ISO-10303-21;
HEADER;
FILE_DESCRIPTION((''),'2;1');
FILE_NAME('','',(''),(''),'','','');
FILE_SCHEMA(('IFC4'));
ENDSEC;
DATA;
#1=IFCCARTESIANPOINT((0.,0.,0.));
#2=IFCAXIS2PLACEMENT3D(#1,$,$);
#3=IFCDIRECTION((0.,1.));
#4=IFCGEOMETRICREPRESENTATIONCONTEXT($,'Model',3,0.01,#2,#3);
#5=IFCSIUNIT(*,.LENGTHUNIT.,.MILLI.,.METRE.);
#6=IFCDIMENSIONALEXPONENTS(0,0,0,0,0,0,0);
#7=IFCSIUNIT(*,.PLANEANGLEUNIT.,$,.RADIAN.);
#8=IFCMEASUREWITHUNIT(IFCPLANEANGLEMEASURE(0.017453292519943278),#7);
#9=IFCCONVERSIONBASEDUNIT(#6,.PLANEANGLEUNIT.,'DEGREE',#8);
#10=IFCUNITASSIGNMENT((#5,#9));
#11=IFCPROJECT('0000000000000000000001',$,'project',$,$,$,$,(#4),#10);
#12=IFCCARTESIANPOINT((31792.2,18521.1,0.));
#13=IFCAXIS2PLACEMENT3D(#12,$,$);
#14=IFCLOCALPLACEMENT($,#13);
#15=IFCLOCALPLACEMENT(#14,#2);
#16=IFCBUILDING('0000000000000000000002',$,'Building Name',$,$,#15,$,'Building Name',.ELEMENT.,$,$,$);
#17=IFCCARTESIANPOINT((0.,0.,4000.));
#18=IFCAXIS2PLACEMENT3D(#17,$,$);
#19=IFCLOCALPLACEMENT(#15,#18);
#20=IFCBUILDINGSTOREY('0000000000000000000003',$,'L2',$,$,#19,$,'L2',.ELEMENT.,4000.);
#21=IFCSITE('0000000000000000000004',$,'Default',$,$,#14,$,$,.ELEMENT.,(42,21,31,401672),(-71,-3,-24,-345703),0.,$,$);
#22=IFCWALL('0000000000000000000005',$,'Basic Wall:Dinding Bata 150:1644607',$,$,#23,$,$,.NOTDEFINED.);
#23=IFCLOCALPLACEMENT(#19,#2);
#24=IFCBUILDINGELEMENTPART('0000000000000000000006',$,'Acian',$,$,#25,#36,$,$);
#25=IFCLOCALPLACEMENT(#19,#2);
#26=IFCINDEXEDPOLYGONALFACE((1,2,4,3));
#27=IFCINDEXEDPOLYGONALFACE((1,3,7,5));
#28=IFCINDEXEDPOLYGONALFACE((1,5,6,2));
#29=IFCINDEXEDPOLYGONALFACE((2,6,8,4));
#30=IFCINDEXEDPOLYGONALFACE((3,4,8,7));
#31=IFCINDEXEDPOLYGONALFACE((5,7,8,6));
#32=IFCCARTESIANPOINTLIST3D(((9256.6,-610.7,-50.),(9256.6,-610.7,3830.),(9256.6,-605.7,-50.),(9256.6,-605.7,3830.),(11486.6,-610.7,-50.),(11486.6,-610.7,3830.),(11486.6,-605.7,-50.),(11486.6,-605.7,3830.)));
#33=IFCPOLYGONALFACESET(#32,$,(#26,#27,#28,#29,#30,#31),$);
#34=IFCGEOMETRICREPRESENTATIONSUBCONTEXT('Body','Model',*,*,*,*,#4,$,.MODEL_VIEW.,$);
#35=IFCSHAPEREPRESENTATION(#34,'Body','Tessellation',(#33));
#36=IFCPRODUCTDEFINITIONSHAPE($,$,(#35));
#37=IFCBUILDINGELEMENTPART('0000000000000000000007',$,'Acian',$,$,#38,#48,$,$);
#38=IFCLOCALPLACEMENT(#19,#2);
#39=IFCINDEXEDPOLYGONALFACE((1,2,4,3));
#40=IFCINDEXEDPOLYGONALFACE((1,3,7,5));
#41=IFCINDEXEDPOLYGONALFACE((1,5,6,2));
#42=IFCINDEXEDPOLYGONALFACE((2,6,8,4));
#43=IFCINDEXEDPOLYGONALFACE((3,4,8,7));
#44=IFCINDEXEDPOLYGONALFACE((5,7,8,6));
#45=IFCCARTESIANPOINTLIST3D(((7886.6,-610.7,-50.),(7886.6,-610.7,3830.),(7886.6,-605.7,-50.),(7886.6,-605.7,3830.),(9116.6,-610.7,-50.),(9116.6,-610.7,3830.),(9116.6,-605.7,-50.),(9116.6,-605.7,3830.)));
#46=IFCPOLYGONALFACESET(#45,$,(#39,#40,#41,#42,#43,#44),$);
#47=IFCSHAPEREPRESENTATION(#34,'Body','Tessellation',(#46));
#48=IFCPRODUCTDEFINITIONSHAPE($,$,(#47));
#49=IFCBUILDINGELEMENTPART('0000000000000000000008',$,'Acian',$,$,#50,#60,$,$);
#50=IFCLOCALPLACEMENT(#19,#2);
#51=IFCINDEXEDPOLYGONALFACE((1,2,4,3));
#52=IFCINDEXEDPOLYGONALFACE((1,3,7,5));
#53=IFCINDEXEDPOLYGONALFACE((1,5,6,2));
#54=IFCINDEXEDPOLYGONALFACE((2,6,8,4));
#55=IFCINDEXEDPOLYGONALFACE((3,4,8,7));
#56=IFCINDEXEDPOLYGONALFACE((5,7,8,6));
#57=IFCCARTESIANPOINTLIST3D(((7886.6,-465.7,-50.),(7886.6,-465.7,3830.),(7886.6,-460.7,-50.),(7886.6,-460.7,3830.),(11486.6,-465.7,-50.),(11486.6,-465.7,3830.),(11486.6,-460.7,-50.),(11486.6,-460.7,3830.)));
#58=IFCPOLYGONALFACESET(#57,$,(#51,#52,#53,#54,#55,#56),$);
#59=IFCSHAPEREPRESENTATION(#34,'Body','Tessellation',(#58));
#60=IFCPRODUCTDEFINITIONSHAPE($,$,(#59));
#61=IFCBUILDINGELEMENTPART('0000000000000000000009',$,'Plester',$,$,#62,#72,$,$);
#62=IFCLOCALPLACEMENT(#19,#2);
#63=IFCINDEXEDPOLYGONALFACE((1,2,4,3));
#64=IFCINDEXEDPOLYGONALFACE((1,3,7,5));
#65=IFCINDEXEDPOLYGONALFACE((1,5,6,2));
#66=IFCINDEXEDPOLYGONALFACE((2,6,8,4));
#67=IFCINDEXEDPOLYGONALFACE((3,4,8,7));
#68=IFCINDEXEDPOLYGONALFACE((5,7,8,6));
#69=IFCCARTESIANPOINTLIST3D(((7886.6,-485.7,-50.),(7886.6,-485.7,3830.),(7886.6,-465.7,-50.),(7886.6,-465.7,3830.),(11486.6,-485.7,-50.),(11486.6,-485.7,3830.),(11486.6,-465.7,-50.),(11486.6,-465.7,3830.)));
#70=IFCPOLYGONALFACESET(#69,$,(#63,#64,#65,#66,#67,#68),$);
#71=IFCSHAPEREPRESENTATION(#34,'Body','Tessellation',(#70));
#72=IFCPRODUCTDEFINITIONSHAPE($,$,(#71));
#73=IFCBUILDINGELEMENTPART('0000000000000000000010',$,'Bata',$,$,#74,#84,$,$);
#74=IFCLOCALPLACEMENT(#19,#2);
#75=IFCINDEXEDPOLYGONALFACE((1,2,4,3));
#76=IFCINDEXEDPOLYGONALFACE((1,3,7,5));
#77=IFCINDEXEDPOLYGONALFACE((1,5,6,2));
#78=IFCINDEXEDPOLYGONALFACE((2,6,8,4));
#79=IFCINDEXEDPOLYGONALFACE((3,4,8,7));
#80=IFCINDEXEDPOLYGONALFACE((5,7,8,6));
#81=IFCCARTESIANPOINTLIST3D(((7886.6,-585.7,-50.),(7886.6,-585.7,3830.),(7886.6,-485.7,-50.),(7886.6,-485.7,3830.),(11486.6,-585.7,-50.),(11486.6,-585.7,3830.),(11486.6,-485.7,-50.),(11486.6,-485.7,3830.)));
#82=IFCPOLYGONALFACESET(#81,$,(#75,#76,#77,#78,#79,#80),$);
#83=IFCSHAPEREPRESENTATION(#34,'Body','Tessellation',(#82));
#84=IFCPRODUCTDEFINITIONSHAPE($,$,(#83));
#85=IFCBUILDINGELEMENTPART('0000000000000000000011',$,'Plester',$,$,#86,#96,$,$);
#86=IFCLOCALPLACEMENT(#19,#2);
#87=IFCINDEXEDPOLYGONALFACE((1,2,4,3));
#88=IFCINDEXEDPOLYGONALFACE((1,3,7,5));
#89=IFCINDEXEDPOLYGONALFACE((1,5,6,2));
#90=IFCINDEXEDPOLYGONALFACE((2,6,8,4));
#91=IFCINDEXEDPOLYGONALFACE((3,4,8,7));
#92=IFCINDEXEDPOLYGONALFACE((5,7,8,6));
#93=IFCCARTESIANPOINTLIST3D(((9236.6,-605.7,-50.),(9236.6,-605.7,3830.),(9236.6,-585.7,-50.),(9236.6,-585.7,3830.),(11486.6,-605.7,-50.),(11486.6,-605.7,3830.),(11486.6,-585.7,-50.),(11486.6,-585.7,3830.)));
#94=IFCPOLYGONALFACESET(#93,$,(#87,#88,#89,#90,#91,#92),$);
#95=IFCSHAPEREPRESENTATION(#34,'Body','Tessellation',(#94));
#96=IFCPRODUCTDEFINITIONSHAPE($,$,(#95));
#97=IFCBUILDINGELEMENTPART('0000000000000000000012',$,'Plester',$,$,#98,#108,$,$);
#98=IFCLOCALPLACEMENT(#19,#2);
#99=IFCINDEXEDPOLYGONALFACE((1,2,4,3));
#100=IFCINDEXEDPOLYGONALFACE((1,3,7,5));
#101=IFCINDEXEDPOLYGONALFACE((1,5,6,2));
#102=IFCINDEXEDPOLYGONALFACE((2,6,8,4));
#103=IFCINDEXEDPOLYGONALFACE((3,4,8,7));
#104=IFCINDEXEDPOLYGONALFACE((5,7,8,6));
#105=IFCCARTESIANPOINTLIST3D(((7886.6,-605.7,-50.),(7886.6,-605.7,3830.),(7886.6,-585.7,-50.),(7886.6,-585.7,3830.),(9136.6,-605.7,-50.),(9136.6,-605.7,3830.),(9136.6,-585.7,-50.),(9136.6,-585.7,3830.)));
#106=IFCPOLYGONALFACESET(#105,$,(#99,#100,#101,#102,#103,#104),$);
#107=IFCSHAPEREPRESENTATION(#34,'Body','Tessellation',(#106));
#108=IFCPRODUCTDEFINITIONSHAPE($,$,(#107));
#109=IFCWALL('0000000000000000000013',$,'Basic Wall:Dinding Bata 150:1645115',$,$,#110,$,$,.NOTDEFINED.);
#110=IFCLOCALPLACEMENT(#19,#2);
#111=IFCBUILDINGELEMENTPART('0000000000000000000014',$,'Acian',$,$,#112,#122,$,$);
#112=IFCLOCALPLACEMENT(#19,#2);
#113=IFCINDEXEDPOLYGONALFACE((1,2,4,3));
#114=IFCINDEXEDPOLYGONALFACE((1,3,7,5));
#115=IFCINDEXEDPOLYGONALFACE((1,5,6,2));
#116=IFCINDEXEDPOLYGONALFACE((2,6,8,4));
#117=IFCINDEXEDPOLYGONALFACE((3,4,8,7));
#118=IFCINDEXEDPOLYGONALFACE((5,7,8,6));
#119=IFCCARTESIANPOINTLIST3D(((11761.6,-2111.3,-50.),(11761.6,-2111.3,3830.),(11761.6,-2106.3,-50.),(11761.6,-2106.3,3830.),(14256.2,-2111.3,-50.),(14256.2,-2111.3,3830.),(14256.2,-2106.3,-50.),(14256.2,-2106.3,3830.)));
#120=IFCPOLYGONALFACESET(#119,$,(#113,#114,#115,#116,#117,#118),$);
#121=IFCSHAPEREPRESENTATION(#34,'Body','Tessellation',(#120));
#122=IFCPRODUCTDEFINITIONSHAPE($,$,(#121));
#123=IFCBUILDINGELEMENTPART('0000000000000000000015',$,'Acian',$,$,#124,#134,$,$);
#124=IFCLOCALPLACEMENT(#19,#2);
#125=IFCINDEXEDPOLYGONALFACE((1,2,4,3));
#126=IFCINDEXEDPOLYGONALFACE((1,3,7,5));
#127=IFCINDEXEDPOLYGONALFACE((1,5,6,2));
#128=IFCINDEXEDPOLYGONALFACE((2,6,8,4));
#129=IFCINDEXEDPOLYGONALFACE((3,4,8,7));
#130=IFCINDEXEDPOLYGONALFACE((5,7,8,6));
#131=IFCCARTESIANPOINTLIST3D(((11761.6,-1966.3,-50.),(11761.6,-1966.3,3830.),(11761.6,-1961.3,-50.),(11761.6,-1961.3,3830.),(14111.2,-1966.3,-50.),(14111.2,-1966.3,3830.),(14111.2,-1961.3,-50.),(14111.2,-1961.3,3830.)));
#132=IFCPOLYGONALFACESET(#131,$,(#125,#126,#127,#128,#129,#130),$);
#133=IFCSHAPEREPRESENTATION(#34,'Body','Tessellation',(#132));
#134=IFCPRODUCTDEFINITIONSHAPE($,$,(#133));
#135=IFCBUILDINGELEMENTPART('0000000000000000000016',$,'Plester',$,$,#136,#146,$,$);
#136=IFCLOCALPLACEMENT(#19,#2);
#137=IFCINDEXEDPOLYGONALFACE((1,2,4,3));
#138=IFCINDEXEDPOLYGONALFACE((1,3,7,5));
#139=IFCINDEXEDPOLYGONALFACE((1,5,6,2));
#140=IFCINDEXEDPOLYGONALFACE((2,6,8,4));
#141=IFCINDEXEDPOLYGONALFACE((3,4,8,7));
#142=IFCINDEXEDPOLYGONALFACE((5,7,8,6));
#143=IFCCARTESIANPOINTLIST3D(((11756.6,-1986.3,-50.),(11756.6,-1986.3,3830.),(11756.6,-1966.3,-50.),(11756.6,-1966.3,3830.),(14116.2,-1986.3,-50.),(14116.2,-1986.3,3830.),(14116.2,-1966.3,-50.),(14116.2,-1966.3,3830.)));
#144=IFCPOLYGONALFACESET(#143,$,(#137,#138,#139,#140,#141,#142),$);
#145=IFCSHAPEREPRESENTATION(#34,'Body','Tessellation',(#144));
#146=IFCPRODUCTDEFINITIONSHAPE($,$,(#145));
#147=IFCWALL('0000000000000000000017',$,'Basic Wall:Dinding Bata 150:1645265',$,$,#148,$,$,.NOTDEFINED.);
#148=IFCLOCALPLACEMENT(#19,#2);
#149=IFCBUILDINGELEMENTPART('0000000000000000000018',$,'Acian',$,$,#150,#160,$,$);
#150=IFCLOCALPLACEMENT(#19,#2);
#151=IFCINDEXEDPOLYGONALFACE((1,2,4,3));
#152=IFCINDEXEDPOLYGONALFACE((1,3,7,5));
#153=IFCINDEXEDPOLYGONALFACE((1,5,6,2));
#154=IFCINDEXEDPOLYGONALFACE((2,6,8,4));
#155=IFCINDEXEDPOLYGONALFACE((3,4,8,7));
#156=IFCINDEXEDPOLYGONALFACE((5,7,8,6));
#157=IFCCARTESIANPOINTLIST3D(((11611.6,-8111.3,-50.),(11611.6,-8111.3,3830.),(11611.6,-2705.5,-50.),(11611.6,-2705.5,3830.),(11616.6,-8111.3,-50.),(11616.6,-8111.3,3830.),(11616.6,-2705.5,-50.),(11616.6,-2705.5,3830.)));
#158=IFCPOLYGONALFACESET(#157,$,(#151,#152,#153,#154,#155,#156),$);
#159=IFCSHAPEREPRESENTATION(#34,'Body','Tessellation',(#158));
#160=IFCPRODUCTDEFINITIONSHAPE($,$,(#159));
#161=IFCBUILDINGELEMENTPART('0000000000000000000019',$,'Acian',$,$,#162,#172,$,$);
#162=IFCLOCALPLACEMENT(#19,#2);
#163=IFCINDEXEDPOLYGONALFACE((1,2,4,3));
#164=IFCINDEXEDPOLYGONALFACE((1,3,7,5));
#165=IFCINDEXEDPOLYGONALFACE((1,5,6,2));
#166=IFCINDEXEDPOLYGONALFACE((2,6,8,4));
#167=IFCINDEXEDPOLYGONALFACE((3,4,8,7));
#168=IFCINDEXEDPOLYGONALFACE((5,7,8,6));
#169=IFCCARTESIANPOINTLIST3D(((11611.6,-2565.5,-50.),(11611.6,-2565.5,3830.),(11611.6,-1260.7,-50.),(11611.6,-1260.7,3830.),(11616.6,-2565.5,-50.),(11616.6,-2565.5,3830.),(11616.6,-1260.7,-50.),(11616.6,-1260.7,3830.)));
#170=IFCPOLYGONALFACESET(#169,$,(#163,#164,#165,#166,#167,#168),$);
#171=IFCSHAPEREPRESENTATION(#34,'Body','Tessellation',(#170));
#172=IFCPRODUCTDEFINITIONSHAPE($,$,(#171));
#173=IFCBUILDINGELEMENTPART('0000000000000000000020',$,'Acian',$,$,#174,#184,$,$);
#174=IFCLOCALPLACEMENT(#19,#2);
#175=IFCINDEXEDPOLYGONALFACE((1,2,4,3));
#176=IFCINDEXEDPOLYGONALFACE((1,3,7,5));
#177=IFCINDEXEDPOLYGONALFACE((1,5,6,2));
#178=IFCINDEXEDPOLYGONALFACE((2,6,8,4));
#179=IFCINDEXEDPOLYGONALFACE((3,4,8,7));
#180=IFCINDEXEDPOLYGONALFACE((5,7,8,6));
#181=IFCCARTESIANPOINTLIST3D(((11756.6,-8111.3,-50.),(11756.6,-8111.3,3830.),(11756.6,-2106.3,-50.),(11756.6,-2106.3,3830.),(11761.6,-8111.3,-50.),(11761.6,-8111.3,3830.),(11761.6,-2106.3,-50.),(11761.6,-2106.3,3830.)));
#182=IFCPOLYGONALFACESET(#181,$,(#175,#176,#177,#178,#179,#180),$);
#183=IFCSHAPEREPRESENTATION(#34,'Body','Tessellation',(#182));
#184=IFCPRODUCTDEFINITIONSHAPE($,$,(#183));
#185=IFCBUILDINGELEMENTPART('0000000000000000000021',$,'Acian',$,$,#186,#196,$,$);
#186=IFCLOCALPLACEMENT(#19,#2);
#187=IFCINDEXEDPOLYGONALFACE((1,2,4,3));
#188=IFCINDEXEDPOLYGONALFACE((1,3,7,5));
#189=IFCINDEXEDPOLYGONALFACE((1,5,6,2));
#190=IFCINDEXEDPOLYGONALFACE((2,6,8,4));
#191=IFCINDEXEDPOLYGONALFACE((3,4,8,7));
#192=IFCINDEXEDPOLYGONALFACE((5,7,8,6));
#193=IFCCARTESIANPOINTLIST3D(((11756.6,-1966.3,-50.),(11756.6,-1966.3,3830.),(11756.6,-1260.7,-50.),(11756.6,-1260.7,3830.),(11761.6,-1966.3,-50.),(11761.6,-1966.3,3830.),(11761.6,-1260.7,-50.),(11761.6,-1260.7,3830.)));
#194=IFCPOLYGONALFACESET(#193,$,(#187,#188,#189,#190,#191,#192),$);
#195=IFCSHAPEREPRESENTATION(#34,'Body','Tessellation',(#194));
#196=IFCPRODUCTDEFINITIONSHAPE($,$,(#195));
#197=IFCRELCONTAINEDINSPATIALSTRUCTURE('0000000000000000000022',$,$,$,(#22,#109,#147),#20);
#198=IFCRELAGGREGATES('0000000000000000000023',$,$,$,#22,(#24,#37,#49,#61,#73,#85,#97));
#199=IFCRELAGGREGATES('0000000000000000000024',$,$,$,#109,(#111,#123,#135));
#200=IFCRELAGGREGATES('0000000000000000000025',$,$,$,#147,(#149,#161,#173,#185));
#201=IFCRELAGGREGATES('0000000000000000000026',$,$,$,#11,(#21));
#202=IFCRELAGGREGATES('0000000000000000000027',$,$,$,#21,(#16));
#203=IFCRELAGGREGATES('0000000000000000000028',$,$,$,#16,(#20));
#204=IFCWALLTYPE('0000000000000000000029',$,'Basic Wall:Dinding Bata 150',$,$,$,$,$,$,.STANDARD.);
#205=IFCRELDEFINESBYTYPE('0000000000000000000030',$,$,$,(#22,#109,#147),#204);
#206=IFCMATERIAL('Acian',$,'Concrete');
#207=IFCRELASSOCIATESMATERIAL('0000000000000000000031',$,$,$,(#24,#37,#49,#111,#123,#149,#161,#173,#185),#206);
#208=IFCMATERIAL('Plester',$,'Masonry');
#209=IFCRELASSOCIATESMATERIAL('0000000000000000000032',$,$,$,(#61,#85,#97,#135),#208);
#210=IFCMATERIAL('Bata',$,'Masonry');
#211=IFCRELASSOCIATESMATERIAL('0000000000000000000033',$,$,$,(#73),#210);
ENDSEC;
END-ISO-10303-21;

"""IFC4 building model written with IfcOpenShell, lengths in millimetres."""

from ifc_helpers import new_model, entity, si_unit, converted_unit, direction, frame, origin, place, context, subcontext, project, spatial, indexed_curve, outline, extrude, material, type_object, element, aggregate, save


model = new_model("IFC4")

# Units and contexts
model_context = context("Model", 3, precision=0.01, world=origin(), true_north=direction((0.0, 1.0)))
body_context = subcontext(model_context, "Body", "Model", "MODEL_VIEW")
ifc_project = project(units=[si_unit("LENGTHUNIT", "METRE", prefix="MILLI"), converted_unit("PLANEANGLEUNIT", "DEGREE", entity("IfcPlaneAngleMeasure", 0.017453292519943278), si_unit("PLANEANGLEUNIT", "RADIAN"), dimensions=[0, 0, 0, 0, 0, 0, 0])], contexts=[model_context])

# Site, building, storey
site_placement = place(None, frame((31792.2, 18521.1, 0.0)))
site = spatial("IfcSite", under=ifc_project, at=site_placement, Name="Default", CompositionType="ELEMENT", RefLatitude=(42, 21, 31, 401672), RefLongitude=(-71, -3, -24, -345703), RefElevation=0.0)
building_placement = place(site_placement, origin())
building = spatial("IfcBuilding", under=site, at=building_placement, Name="Building Name", LongName="Building Name", CompositionType="ELEMENT")
storey_placement = place(building_placement, frame((0.0, 0.0, 4000.0)))
storey = spatial("IfcBuildingStorey", under=building, at=storey_placement, Name="L2", LongName="L2", CompositionType="ELEMENT", Elevation=4000.0)

# Walls, building element parts
wall_type = type_object("IfcWallType", Name="Basic Wall:Dinding Bata 150", PredefinedType="STANDARD")
wall_1_placement = place(storey_placement, frame((7886.6, -535.7, -50.0)))
wall_1 = element("IfcWall", 1, at=wall_1_placement, inside=storey, type_object=wall_type, Name="Basic Wall:Dinding Bata 150:1644607", PredefinedType="NOTDEFINED")
ifc_material_1 = material(Name="Acian", Category="Concrete")
building_element_part_1_placement = place(wall_1_placement, origin())
building_element_part_1 = element("IfcBuildingElementPart", 2, at=building_element_part_1_placement, material=ifc_material_1, Name="Acian", context=body_context, shape_type="SweptSolid", body=[
    extrude(outline(indexed_curve([(-2.5, -1115.0), (2.5, -1115.0), (2.5, 1115.0), (-2.5, 1115.0), (-2.5, -1115.0)], self_intersect=False)), frame((2485.0, -72.5, 0.0), z_axis=(0.0, 0.0, 1.0), x_axis=(0.0, -1.0, 0.0)), (0.0, 0.0, 1.0), 3880.0),
])
building_element_part_2_placement = place(wall_1_placement, origin())
building_element_part_2 = element("IfcBuildingElementPart", 3, at=building_element_part_2_placement, material=ifc_material_1, Name="Acian", context=body_context, shape_type="SweptSolid", body=[
    extrude(outline(indexed_curve([(-2.5, -615.0), (2.5, -615.0), (2.5, 615.0), (-2.5, 615.0), (-2.5, -615.0)], self_intersect=False)), frame((615.0, -72.5, 0.0), z_axis=(0.0, 0.0, 1.0), x_axis=(0.0, -1.0, 0.0)), (0.0, 0.0, 1.0), 3880.0),
])
building_element_part_3_placement = place(wall_1_placement, origin())
building_element_part_3 = element("IfcBuildingElementPart", 4, at=building_element_part_3_placement, material=ifc_material_1, Name="Acian", context=body_context, shape_type="SweptSolid", body=[
    extrude(outline(indexed_curve([(-2.5, -1800.0), (2.5, -1800.0), (2.5, 1800.0), (-2.5, 1800.0), (-2.5, -1800.0)], self_intersect=False)), frame((1800.0, 72.5, 0.0), z_axis=(0.0, 0.0, 1.0), x_axis=(0.0, -1.0, 0.0)), (0.0, 0.0, 1.0), 3880.0),
])
ifc_material_2 = material(Name="Plester", Category="Masonry")
building_element_part_4_placement = place(wall_1_placement, origin())
building_element_part_4 = element("IfcBuildingElementPart", 5, at=building_element_part_4_placement, material=ifc_material_2, Name="Plester", context=body_context, shape_type="SweptSolid", body=[
    extrude(outline(indexed_curve([(-10.0, -1800.0), (10.0, -1800.0), (10.0, 1800.0), (-10.0, 1800.0), (-10.0, -1800.0)], self_intersect=False)), frame((1800.0, 60.0, 0.0), z_axis=(0.0, 0.0, 1.0), x_axis=(0.0, -1.0, 0.0)), (0.0, 0.0, 1.0), 3880.0),
])
ifc_material_3 = material(Name="Bata", Category="Masonry")
building_element_part_5_placement = place(wall_1_placement, origin())
building_element_part_5 = element("IfcBuildingElementPart", 6, at=building_element_part_5_placement, material=ifc_material_3, Name="Bata", context=body_context, shape_type="SweptSolid", body=[
    extrude(outline(indexed_curve([(-50.0, -1800.0), (50.0, -1800.0), (50.0, 1800.0), (-50.0, 1800.0), (-50.0, -1800.0)], self_intersect=False)), frame((1800.0, 0.0, 0.0), z_axis=(0.0, 0.0, 1.0), x_axis=(0.0, -1.0, 0.0)), (0.0, 0.0, 1.0), 3880.0),
])
building_element_part_6_placement = place(wall_1_placement, origin())
building_element_part_6 = element("IfcBuildingElementPart", 7, at=building_element_part_6_placement, material=ifc_material_2, Name="Plester", context=body_context, shape_type="SweptSolid", body=[
    extrude(outline(indexed_curve([(-10.0, -1125.0), (10.0, -1125.0), (10.0, 1125.0), (-10.0, 1125.0), (-10.0, -1125.0)], self_intersect=False)), frame((2475.0, -60.0, 0.0), z_axis=(0.0, 0.0, 1.0), x_axis=(0.0, -1.0, 0.0)), (0.0, 0.0, 1.0), 3880.0),
])
building_element_part_7_placement = place(wall_1_placement, origin())
building_element_part_7 = element("IfcBuildingElementPart", 8, at=building_element_part_7_placement, material=ifc_material_2, Name="Plester", context=body_context, shape_type="SweptSolid", body=[
    extrude(outline(indexed_curve([(-10.0, -625.0), (10.0, -625.0), (10.0, 625.0), (-10.0, 625.0), (-10.0, -625.0)], self_intersect=False)), frame((625.0, -60.0, 0.0), z_axis=(0.0, 0.0, 1.0), x_axis=(0.0, -1.0, 0.0)), (0.0, 0.0, 1.0), 3880.0),
])
aggregate(wall_1, [building_element_part_1, building_element_part_2, building_element_part_3, building_element_part_4, building_element_part_5, building_element_part_6, building_element_part_7])
wall_2_placement = place(storey_placement, frame((11761.6, -2036.3, -50.0)))
wall_2 = element("IfcWall", 9, at=wall_2_placement, inside=storey, type_object=wall_type, Name="Basic Wall:Dinding Bata 150:1645115", PredefinedType="NOTDEFINED")
building_element_part_8_placement = place(wall_2_placement, origin())
building_element_part_8 = element("IfcBuildingElementPart", 10, at=building_element_part_8_placement, material=ifc_material_1, Name="Acian", context=body_context, shape_type="SweptSolid", body=[
    extrude(outline(indexed_curve([(-2.5, -1247.3), (2.5, -1247.3), (2.5, 1247.3), (-2.5, 1247.3), (-2.5, -1247.3)], self_intersect=False)), frame((1247.3, -72.5, 0.0), z_axis=(0.0, 0.0, 1.0), x_axis=(0.0, -1.0, 0.0)), (0.0, 0.0, 1.0), 3880.0),
])
building_element_part_9_placement = place(wall_2_placement, origin())
building_element_part_9 = element("IfcBuildingElementPart", 11, at=building_element_part_9_placement, material=ifc_material_1, Name="Acian", context=body_context, shape_type="SweptSolid", body=[
    extrude(outline(indexed_curve([(-2.5, -1174.8), (2.5, -1174.8), (2.5, 1174.8), (-2.5, 1174.8), (-2.5, -1174.8)], self_intersect=False)), frame((1174.8, 72.5, 0.0), z_axis=(0.0, 0.0, 1.0), x_axis=(0.0, -1.0, 0.0)), (0.0, 0.0, 1.0), 3880.0),
])
building_element_part_10_placement = place(wall_2_placement, origin())
building_element_part_10 = element("IfcBuildingElementPart", 12, at=building_element_part_10_placement, material=ifc_material_2, Name="Plester", context=body_context, shape_type="SweptSolid", body=[
    extrude(outline(indexed_curve([(-10.0, -1179.8), (10.0, -1179.8), (10.0, 1179.8), (-10.0, 1179.8), (-10.0, -1179.8)], self_intersect=False)), frame((1174.8, 60.0, 0.0), z_axis=(0.0, 0.0, 1.0), x_axis=(0.0, -1.0, 0.0)), (0.0, 0.0, 1.0), 3880.0),
])
aggregate(wall_2, [building_element_part_8, building_element_part_9, building_element_part_10])
wall_3_placement = place(storey_placement, frame((11686.6, -1260.7, -50.0), z_axis=(0.0, 0.0, 1.0), x_axis=(0.0, -1.0, 0.0)))
wall_3 = element("IfcWall", 13, at=wall_3_placement, inside=storey, type_object=wall_type, Name="Basic Wall:Dinding Bata 150:1645265", PredefinedType="NOTDEFINED")
building_element_part_11_placement = place(wall_3_placement, origin())
building_element_part_11 = element("IfcBuildingElementPart", 14, at=building_element_part_11_placement, material=ifc_material_1, Name="Acian", context=body_context, shape_type="SweptSolid", body=[
    extrude(outline(indexed_curve([(-2702.9, -2.5), (2702.9, -2.5), (2702.9, 2.5), (-2702.9, 2.5), (-2702.9, -2.5)], self_intersect=False)), frame((4147.6, -72.5, 0.0)), (0.0, 0.0, 1.0), 3880.0),
])
building_element_part_12_placement = place(wall_3_placement, origin())
building_element_part_12 = element("IfcBuildingElementPart", 15, at=building_element_part_12_placement, material=ifc_material_1, Name="Acian", context=body_context, shape_type="SweptSolid", body=[
    extrude(outline(indexed_curve([(-652.4, -2.5), (652.4, -2.5), (652.4, 2.5), (-652.4, 2.5), (-652.4, -2.5)], self_intersect=False)), frame((652.4, -72.5, 0.0)), (0.0, 0.0, 1.0), 3880.0),
])
building_element_part_13_placement = place(wall_3_placement, origin())
building_element_part_13 = element("IfcBuildingElementPart", 16, at=building_element_part_13_placement, material=ifc_material_1, Name="Acian", context=body_context, shape_type="SweptSolid", body=[
    extrude(outline(indexed_curve([(-3002.5, -2.5), (3002.5, -2.5), (3002.5, 2.5), (-3002.5, 2.5), (-3002.5, -2.5)], self_intersect=False)), frame((3848.1, 72.5, 0.0)), (0.0, 0.0, 1.0), 3880.0),
])
building_element_part_14_placement = place(wall_3_placement, origin())
building_element_part_14 = element("IfcBuildingElementPart", 17, at=building_element_part_14_placement, material=ifc_material_1, Name="Acian", context=body_context, shape_type="SweptSolid", body=[
    extrude(outline(indexed_curve([(-352.8, -2.5), (352.8, -2.5), (352.8, 2.5), (-352.8, 2.5), (-352.8, -2.5)], self_intersect=False)), frame((352.8, 72.5, 0.0)), (0.0, 0.0, 1.0), 3880.0),
])
aggregate(wall_3, [building_element_part_11, building_element_part_12, building_element_part_13, building_element_part_14])

save(model, "model.ifc")
